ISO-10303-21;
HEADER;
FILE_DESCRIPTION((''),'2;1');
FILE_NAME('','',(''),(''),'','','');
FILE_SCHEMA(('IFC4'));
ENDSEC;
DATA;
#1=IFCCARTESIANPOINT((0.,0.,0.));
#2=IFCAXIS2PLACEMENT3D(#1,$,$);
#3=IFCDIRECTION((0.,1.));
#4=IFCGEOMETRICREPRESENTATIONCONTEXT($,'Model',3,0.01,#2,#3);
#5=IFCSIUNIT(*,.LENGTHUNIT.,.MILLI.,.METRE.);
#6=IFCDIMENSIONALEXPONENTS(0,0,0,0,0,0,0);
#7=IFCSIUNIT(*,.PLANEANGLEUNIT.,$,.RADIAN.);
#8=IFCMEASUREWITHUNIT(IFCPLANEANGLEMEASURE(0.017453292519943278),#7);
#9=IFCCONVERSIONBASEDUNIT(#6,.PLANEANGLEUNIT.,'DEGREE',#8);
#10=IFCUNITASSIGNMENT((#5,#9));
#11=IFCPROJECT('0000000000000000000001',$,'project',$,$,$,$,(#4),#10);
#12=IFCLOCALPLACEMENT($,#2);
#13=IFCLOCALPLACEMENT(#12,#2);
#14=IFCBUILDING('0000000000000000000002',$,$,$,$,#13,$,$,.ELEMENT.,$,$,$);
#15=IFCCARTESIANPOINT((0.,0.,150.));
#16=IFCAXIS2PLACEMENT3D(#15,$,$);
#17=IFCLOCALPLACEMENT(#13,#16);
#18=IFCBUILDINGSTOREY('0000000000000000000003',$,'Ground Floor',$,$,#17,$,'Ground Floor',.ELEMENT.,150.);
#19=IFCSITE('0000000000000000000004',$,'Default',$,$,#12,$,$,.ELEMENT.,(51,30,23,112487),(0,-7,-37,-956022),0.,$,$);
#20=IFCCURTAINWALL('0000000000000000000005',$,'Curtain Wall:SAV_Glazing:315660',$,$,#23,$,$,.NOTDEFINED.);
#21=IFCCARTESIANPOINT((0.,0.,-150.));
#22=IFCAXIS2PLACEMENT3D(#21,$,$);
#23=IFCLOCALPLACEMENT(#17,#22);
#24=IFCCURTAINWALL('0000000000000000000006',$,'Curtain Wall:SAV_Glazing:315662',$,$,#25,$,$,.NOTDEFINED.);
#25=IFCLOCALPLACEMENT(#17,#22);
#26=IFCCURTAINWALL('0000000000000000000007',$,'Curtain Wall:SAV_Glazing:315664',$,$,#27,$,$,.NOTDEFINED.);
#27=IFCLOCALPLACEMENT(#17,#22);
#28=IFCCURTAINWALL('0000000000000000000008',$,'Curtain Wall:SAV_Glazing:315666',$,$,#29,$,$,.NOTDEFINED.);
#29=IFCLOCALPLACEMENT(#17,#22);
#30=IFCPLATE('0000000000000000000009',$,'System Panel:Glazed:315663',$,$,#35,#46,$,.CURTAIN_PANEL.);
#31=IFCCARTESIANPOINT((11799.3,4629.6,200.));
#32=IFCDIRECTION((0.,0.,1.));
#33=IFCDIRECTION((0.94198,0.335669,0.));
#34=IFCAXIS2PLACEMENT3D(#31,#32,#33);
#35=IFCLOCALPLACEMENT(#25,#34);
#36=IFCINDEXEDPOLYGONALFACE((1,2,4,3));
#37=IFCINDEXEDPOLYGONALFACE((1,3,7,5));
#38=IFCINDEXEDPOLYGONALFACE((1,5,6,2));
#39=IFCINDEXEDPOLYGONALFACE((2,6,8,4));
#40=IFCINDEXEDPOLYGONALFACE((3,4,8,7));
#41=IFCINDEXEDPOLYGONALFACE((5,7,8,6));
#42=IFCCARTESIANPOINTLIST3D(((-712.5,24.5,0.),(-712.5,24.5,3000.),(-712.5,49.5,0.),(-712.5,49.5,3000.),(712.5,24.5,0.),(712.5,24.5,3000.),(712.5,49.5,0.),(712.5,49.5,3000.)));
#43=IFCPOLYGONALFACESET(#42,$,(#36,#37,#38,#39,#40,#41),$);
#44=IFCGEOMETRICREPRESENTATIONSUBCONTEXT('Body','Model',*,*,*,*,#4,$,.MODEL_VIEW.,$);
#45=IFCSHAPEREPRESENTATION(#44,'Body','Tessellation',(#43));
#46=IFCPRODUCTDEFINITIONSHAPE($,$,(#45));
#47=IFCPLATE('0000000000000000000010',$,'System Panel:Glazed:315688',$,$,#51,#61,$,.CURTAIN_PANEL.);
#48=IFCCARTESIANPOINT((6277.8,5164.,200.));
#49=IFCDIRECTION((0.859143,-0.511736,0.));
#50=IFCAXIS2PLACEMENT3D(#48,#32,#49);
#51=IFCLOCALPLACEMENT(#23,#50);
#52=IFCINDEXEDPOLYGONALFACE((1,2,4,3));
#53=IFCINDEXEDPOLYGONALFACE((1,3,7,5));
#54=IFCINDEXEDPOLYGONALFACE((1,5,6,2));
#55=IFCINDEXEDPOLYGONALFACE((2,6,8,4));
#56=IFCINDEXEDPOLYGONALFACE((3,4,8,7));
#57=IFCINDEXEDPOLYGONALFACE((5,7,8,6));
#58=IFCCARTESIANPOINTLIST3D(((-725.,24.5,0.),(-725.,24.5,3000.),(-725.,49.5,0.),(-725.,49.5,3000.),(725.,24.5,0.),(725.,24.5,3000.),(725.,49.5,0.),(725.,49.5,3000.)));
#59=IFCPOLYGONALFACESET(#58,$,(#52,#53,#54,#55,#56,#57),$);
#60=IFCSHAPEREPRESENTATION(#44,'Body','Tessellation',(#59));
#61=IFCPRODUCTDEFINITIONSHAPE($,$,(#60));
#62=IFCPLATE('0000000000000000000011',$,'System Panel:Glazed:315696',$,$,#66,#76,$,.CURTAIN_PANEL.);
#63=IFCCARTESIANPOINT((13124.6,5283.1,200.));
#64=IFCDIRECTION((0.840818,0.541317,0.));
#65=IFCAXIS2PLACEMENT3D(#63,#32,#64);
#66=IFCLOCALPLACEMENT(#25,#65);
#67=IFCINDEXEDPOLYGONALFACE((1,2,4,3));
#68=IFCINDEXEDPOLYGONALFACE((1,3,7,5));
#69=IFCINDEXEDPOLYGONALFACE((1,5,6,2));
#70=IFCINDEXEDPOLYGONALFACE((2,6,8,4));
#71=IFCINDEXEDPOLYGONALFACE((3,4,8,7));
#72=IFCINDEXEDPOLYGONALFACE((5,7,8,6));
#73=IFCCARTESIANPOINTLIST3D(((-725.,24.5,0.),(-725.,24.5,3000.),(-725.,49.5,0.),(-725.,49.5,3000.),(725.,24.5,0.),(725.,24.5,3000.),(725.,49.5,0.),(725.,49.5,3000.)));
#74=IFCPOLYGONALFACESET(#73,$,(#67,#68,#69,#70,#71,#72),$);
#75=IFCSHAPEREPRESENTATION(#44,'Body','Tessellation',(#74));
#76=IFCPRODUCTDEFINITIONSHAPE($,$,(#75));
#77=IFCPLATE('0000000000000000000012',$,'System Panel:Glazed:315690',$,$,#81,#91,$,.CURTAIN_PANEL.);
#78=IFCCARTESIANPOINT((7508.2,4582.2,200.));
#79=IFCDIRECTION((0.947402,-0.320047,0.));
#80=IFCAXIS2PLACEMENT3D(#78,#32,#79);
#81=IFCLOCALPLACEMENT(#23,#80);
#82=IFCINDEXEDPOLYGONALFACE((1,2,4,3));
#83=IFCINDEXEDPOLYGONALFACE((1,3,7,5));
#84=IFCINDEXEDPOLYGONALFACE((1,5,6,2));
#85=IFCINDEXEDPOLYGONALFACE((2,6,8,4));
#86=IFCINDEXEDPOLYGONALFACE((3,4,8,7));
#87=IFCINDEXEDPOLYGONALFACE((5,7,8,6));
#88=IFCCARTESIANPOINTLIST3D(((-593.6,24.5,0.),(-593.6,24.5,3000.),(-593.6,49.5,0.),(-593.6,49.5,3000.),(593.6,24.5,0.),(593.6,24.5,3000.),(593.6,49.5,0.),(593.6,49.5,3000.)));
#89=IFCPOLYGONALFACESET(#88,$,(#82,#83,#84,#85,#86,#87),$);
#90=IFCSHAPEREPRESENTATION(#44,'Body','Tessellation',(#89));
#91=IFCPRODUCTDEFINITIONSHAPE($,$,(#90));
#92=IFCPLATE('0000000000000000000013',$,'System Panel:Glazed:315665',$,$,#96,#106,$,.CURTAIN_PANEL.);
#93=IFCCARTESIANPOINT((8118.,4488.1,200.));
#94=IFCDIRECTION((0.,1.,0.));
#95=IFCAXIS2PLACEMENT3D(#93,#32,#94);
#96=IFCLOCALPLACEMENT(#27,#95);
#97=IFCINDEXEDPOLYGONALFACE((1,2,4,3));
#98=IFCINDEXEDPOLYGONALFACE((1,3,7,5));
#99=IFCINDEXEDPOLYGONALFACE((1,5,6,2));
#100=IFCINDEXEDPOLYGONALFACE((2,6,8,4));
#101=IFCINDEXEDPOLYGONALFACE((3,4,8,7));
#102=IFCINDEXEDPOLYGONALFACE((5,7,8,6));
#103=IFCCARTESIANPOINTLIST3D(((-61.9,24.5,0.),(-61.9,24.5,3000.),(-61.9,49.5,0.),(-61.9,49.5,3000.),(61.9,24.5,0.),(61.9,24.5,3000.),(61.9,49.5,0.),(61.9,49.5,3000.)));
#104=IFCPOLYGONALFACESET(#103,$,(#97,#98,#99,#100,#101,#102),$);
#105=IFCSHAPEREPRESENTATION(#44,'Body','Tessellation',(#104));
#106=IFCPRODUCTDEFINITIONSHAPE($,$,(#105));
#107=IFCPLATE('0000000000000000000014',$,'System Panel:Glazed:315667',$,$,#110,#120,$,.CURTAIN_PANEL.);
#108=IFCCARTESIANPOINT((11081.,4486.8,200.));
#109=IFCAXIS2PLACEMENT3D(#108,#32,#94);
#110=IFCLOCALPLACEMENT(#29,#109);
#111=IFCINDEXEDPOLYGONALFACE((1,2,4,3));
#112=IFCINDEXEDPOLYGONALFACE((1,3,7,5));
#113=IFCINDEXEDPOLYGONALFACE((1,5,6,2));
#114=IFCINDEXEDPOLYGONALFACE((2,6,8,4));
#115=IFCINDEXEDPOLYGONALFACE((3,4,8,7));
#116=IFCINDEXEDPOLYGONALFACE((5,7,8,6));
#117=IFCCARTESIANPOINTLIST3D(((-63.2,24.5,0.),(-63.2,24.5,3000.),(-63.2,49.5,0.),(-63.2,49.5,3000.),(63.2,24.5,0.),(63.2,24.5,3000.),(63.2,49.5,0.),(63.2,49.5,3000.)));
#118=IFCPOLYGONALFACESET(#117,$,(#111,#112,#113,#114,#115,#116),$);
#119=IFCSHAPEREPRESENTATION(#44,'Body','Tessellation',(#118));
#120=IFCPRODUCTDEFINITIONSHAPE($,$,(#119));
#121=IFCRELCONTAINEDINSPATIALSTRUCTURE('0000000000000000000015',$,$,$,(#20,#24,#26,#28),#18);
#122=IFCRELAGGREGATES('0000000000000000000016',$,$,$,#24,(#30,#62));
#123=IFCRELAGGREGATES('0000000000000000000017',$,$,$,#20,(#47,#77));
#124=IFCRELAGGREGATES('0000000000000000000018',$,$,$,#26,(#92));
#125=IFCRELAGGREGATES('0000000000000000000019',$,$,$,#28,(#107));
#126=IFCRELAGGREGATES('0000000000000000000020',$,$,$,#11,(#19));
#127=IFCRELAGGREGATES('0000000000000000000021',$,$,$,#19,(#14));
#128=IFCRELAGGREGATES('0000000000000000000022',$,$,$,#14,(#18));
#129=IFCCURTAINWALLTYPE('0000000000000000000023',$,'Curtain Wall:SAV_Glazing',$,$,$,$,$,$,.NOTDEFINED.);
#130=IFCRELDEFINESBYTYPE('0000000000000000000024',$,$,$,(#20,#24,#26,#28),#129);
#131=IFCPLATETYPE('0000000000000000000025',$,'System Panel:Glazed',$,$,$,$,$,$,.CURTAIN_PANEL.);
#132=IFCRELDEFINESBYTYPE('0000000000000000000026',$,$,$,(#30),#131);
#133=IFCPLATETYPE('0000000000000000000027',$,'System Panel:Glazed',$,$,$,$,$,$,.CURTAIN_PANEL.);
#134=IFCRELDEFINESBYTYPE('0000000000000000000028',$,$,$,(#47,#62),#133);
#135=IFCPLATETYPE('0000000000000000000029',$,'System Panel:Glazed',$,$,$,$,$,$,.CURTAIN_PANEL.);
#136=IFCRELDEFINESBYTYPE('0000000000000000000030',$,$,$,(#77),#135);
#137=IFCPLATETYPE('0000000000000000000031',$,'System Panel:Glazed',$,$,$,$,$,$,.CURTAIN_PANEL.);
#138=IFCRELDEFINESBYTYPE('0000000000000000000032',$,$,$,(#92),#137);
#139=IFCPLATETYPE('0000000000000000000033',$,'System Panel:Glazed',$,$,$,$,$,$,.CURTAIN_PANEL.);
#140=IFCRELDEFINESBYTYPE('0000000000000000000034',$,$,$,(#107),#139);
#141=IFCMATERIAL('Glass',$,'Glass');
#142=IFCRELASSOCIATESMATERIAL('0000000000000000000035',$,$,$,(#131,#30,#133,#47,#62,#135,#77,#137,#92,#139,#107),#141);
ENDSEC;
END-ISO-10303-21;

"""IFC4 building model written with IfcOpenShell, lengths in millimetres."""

from ifc_helpers import new_model, entity, si_unit, converted_unit, direction, frame, frame_2d, origin, origin_2d_with_axis, place, context, subcontext, project, spatial, rectangle, extrude, source, transform, mapped, material, type_object, type_shapes, element, aggregate, save


model = new_model("IFC4")

# Units and contexts
model_context = context("Model", 3, precision=0.01, world=origin(), true_north=direction((0.0, 1.0)))
body_context = subcontext(model_context, "Body", "Model", "MODEL_VIEW")
ifc_project = project(units=[si_unit("LENGTHUNIT", "METRE", prefix="MILLI"), converted_unit("PLANEANGLEUNIT", "DEGREE", entity("IfcPlaneAngleMeasure", 0.017453292519943278), si_unit("PLANEANGLEUNIT", "RADIAN"), dimensions=[0, 0, 0, 0, 0, 0, 0])], contexts=[model_context])

# Site, building, storey
site_placement = place(None, origin())
site = spatial("IfcSite", under=ifc_project, at=site_placement, Name="Default", CompositionType="ELEMENT", RefLatitude=(51, 30, 23, 112487), RefLongitude=(0, -7, -37, -956022), RefElevation=0.0)
building_placement = place(site_placement, origin())
building = spatial("IfcBuilding", under=site, at=building_placement, CompositionType="ELEMENT")
storey_placement = place(building_placement, frame((0.0, 0.0, 150.0)))
storey = spatial("IfcBuildingStorey", under=building, at=storey_placement, Name="Ground Floor", LongName="Ground Floor", CompositionType="ELEMENT", Elevation=150.0)

# Curtain walls
curtain_wall_type = type_object("IfcCurtainWallType", Name="Curtain Wall:SAV_Glazing", PredefinedType="NOTDEFINED")
curtain_wall_1_placement = place(storey_placement, frame((0.0, 0.0, -150.0)))
curtain_wall_1 = element("IfcCurtainWall", 1, at=curtain_wall_1_placement, inside=storey, type_object=curtain_wall_type, Name="Curtain Wall:SAV_Glazing:315660", PredefinedType="NOTDEFINED")
curtain_wall_2_placement = place(storey_placement, frame((0.0, 0.0, -150.0)))
curtain_wall_2 = element("IfcCurtainWall", 2, at=curtain_wall_2_placement, inside=storey, type_object=curtain_wall_type, Name="Curtain Wall:SAV_Glazing:315662", PredefinedType="NOTDEFINED")

# Curtain walls
curtain_wall_3_placement = place(storey_placement, frame((0.0, 0.0, -150.0)))
curtain_wall_3 = element("IfcCurtainWall", 3, at=curtain_wall_3_placement, inside=storey, type_object=curtain_wall_type, Name="Curtain Wall:SAV_Glazing:315664", PredefinedType="NOTDEFINED")
curtain_wall_4_placement = place(storey_placement, frame((0.0, 0.0, -150.0)))
curtain_wall_4 = element("IfcCurtainWall", 4, at=curtain_wall_4_placement, inside=storey, type_object=curtain_wall_type, Name="Curtain Wall:SAV_Glazing:315666", PredefinedType="NOTDEFINED")

# Plates
ifc_material_1 = material(Name="Glass", Category="Glass")
plate_type_1 = type_object("IfcPlateType", Name="System Panel:Glazed", PredefinedType="CURTAIN_PANEL", material=ifc_material_1)
shared_shape_1 = source(origin(), body_context, "Body", "SweptSolid", [
    extrude(rectangle(XDim=25.0, YDim=1425.0, at=frame_2d((0.0, 0.0), x_axis=(1.0, 0.0))), frame((0.0, 37.0, 0.0), z_axis=(0.0, 0.0, 1.0), x_axis=(0.0, 1.0, 0.0)), (0.0, 0.0, 1.0), 3000.0),
])
type_shapes(plate_type_1, [shared_shape_1])
plate_1_placement = place(curtain_wall_2_placement, frame((11799.3, 4629.6, 200.0), z_axis=(0.0, 0.0, 1.0), x_axis=(0.94198, 0.335669, 0.0)))
plate_1 = element("IfcPlate", 5, at=plate_1_placement, type_object=plate_type_1, material=ifc_material_1, Name="System Panel:Glazed:315663", PredefinedType="CURTAIN_PANEL", context=body_context, shape_type="MappedRepresentation", body=[
    mapped(shared_shape_1, transform((0.0, 0.0, 0.0), scale=1.0)),
])
plate_type_2 = type_object("IfcPlateType", Name="System Panel:Glazed", PredefinedType="CURTAIN_PANEL", material=ifc_material_1)
shared_shape_2 = source(origin(), body_context, "Body", "SweptSolid", [
    extrude(rectangle(XDim=25.0, YDim=1450.0, at=frame_2d((0.0, 0.0), x_axis=(1.0, 0.0))), frame((0.0, 37.0, 0.0), z_axis=(0.0, 0.0, 1.0), x_axis=(0.0, 1.0, 0.0)), (0.0, 0.0, 1.0), 3000.0),
])
type_shapes(plate_type_2, [shared_shape_2])
plate_2_placement = place(curtain_wall_1_placement, frame((6277.8, 5164.0, 200.0), z_axis=(0.0, 0.0, 1.0), x_axis=(0.859143, -0.511736, 0.0)))
plate_2 = element("IfcPlate", 6, at=plate_2_placement, type_object=plate_type_2, material=ifc_material_1, Name="System Panel:Glazed:315688", PredefinedType="CURTAIN_PANEL", context=body_context, shape_type="MappedRepresentation", body=[
    mapped(shared_shape_2, transform((0.0, 0.0, 0.0), scale=1.0)),
])
plate_3_placement = place(curtain_wall_2_placement, frame((13124.6, 5283.1, 200.0), z_axis=(0.0, 0.0, 1.0), x_axis=(0.840818, 0.541317, 0.0)))
plate_3 = element("IfcPlate", 7, at=plate_3_placement, type_object=plate_type_2, material=ifc_material_1, Name="System Panel:Glazed:315696", PredefinedType="CURTAIN_PANEL", context=body_context, shape_type="MappedRepresentation", body=[
    mapped(shared_shape_2, transform((0.0, 0.0, 0.0), scale=1.0)),
])
aggregate(curtain_wall_2, [plate_1, plate_3])
plate_type_3 = type_object("IfcPlateType", Name="System Panel:Glazed", PredefinedType="CURTAIN_PANEL", material=ifc_material_1)
shared_shape_3 = source(origin(), body_context, "Body", "SweptSolid", [
    extrude(rectangle(XDim=25.0, YDim=1187.3, at=frame_2d((0.0, 0.0), x_axis=(1.0, 0.0))), frame((0.0, 37.0, 0.0), z_axis=(0.0, 0.0, 1.0), x_axis=(0.0, 1.0, 0.0)), (0.0, 0.0, 1.0), 3000.0),
])
type_shapes(plate_type_3, [shared_shape_3])
plate_4_placement = place(curtain_wall_1_placement, frame((7508.2, 4582.2, 200.0), z_axis=(0.0, 0.0, 1.0), x_axis=(0.947402, -0.320047, 0.0)))
plate_4 = element("IfcPlate", 8, at=plate_4_placement, type_object=plate_type_3, material=ifc_material_1, Name="System Panel:Glazed:315690", PredefinedType="CURTAIN_PANEL", context=body_context, shape_type="MappedRepresentation", body=[
    mapped(shared_shape_3, transform((0.0, 0.0, 0.0), scale=1.0)),
])
aggregate(curtain_wall_1, [plate_2, plate_4])
plate_type_4 = type_object("IfcPlateType", Name="System Panel:Glazed", PredefinedType="CURTAIN_PANEL", material=ifc_material_1)
shared_shape_4 = source(origin(), body_context, "Body", "SweptSolid", [
    extrude(rectangle(XDim=25.0, YDim=123.8, at=origin_2d_with_axis()), frame((0.0, 37.0, 0.0), z_axis=(0.0, 0.0, 1.0), x_axis=(0.0, 1.0, 0.0)), (0.0, 0.0, 1.0), 3000.0),
])
type_shapes(plate_type_4, [shared_shape_4])
plate_5_placement = place(curtain_wall_3_placement, frame((8118.0, 4488.1, 200.0), z_axis=(0.0, 0.0, 1.0), x_axis=(0.0, 1.0, 0.0)))
plate_5 = element("IfcPlate", 9, at=plate_5_placement, type_object=plate_type_4, material=ifc_material_1, Name="System Panel:Glazed:315665", PredefinedType="CURTAIN_PANEL", context=body_context, shape_type="MappedRepresentation", body=[
    mapped(shared_shape_4, transform((0.0, 0.0, 0.0), scale=1.0)),
])
aggregate(curtain_wall_3, [plate_5])
plate_type_5 = type_object("IfcPlateType", Name="System Panel:Glazed", PredefinedType="CURTAIN_PANEL", material=ifc_material_1)
shared_shape_5 = source(origin(), body_context, "Body", "SweptSolid", [
    extrude(rectangle(XDim=25.0, YDim=126.4, at=origin_2d_with_axis()), frame((0.0, 37.0, 0.0), z_axis=(0.0, 0.0, 1.0), x_axis=(0.0, 1.0, 0.0)), (0.0, 0.0, 1.0), 3000.0),
])
type_shapes(plate_type_5, [shared_shape_5])
plate_6_placement = place(curtain_wall_4_placement, frame((11081.0, 4486.8, 200.0), z_axis=(0.0, 0.0, 1.0), x_axis=(0.0, 1.0, 0.0)))
plate_6 = element("IfcPlate", 10, at=plate_6_placement, type_object=plate_type_5, material=ifc_material_1, Name="System Panel:Glazed:315667", PredefinedType="CURTAIN_PANEL", context=body_context, shape_type="MappedRepresentation", body=[
    mapped(shared_shape_5, transform((0.0, 0.0, 0.0), scale=1.0)),
])
aggregate(curtain_wall_4, [plate_6])

save(model, "model.ifc")
